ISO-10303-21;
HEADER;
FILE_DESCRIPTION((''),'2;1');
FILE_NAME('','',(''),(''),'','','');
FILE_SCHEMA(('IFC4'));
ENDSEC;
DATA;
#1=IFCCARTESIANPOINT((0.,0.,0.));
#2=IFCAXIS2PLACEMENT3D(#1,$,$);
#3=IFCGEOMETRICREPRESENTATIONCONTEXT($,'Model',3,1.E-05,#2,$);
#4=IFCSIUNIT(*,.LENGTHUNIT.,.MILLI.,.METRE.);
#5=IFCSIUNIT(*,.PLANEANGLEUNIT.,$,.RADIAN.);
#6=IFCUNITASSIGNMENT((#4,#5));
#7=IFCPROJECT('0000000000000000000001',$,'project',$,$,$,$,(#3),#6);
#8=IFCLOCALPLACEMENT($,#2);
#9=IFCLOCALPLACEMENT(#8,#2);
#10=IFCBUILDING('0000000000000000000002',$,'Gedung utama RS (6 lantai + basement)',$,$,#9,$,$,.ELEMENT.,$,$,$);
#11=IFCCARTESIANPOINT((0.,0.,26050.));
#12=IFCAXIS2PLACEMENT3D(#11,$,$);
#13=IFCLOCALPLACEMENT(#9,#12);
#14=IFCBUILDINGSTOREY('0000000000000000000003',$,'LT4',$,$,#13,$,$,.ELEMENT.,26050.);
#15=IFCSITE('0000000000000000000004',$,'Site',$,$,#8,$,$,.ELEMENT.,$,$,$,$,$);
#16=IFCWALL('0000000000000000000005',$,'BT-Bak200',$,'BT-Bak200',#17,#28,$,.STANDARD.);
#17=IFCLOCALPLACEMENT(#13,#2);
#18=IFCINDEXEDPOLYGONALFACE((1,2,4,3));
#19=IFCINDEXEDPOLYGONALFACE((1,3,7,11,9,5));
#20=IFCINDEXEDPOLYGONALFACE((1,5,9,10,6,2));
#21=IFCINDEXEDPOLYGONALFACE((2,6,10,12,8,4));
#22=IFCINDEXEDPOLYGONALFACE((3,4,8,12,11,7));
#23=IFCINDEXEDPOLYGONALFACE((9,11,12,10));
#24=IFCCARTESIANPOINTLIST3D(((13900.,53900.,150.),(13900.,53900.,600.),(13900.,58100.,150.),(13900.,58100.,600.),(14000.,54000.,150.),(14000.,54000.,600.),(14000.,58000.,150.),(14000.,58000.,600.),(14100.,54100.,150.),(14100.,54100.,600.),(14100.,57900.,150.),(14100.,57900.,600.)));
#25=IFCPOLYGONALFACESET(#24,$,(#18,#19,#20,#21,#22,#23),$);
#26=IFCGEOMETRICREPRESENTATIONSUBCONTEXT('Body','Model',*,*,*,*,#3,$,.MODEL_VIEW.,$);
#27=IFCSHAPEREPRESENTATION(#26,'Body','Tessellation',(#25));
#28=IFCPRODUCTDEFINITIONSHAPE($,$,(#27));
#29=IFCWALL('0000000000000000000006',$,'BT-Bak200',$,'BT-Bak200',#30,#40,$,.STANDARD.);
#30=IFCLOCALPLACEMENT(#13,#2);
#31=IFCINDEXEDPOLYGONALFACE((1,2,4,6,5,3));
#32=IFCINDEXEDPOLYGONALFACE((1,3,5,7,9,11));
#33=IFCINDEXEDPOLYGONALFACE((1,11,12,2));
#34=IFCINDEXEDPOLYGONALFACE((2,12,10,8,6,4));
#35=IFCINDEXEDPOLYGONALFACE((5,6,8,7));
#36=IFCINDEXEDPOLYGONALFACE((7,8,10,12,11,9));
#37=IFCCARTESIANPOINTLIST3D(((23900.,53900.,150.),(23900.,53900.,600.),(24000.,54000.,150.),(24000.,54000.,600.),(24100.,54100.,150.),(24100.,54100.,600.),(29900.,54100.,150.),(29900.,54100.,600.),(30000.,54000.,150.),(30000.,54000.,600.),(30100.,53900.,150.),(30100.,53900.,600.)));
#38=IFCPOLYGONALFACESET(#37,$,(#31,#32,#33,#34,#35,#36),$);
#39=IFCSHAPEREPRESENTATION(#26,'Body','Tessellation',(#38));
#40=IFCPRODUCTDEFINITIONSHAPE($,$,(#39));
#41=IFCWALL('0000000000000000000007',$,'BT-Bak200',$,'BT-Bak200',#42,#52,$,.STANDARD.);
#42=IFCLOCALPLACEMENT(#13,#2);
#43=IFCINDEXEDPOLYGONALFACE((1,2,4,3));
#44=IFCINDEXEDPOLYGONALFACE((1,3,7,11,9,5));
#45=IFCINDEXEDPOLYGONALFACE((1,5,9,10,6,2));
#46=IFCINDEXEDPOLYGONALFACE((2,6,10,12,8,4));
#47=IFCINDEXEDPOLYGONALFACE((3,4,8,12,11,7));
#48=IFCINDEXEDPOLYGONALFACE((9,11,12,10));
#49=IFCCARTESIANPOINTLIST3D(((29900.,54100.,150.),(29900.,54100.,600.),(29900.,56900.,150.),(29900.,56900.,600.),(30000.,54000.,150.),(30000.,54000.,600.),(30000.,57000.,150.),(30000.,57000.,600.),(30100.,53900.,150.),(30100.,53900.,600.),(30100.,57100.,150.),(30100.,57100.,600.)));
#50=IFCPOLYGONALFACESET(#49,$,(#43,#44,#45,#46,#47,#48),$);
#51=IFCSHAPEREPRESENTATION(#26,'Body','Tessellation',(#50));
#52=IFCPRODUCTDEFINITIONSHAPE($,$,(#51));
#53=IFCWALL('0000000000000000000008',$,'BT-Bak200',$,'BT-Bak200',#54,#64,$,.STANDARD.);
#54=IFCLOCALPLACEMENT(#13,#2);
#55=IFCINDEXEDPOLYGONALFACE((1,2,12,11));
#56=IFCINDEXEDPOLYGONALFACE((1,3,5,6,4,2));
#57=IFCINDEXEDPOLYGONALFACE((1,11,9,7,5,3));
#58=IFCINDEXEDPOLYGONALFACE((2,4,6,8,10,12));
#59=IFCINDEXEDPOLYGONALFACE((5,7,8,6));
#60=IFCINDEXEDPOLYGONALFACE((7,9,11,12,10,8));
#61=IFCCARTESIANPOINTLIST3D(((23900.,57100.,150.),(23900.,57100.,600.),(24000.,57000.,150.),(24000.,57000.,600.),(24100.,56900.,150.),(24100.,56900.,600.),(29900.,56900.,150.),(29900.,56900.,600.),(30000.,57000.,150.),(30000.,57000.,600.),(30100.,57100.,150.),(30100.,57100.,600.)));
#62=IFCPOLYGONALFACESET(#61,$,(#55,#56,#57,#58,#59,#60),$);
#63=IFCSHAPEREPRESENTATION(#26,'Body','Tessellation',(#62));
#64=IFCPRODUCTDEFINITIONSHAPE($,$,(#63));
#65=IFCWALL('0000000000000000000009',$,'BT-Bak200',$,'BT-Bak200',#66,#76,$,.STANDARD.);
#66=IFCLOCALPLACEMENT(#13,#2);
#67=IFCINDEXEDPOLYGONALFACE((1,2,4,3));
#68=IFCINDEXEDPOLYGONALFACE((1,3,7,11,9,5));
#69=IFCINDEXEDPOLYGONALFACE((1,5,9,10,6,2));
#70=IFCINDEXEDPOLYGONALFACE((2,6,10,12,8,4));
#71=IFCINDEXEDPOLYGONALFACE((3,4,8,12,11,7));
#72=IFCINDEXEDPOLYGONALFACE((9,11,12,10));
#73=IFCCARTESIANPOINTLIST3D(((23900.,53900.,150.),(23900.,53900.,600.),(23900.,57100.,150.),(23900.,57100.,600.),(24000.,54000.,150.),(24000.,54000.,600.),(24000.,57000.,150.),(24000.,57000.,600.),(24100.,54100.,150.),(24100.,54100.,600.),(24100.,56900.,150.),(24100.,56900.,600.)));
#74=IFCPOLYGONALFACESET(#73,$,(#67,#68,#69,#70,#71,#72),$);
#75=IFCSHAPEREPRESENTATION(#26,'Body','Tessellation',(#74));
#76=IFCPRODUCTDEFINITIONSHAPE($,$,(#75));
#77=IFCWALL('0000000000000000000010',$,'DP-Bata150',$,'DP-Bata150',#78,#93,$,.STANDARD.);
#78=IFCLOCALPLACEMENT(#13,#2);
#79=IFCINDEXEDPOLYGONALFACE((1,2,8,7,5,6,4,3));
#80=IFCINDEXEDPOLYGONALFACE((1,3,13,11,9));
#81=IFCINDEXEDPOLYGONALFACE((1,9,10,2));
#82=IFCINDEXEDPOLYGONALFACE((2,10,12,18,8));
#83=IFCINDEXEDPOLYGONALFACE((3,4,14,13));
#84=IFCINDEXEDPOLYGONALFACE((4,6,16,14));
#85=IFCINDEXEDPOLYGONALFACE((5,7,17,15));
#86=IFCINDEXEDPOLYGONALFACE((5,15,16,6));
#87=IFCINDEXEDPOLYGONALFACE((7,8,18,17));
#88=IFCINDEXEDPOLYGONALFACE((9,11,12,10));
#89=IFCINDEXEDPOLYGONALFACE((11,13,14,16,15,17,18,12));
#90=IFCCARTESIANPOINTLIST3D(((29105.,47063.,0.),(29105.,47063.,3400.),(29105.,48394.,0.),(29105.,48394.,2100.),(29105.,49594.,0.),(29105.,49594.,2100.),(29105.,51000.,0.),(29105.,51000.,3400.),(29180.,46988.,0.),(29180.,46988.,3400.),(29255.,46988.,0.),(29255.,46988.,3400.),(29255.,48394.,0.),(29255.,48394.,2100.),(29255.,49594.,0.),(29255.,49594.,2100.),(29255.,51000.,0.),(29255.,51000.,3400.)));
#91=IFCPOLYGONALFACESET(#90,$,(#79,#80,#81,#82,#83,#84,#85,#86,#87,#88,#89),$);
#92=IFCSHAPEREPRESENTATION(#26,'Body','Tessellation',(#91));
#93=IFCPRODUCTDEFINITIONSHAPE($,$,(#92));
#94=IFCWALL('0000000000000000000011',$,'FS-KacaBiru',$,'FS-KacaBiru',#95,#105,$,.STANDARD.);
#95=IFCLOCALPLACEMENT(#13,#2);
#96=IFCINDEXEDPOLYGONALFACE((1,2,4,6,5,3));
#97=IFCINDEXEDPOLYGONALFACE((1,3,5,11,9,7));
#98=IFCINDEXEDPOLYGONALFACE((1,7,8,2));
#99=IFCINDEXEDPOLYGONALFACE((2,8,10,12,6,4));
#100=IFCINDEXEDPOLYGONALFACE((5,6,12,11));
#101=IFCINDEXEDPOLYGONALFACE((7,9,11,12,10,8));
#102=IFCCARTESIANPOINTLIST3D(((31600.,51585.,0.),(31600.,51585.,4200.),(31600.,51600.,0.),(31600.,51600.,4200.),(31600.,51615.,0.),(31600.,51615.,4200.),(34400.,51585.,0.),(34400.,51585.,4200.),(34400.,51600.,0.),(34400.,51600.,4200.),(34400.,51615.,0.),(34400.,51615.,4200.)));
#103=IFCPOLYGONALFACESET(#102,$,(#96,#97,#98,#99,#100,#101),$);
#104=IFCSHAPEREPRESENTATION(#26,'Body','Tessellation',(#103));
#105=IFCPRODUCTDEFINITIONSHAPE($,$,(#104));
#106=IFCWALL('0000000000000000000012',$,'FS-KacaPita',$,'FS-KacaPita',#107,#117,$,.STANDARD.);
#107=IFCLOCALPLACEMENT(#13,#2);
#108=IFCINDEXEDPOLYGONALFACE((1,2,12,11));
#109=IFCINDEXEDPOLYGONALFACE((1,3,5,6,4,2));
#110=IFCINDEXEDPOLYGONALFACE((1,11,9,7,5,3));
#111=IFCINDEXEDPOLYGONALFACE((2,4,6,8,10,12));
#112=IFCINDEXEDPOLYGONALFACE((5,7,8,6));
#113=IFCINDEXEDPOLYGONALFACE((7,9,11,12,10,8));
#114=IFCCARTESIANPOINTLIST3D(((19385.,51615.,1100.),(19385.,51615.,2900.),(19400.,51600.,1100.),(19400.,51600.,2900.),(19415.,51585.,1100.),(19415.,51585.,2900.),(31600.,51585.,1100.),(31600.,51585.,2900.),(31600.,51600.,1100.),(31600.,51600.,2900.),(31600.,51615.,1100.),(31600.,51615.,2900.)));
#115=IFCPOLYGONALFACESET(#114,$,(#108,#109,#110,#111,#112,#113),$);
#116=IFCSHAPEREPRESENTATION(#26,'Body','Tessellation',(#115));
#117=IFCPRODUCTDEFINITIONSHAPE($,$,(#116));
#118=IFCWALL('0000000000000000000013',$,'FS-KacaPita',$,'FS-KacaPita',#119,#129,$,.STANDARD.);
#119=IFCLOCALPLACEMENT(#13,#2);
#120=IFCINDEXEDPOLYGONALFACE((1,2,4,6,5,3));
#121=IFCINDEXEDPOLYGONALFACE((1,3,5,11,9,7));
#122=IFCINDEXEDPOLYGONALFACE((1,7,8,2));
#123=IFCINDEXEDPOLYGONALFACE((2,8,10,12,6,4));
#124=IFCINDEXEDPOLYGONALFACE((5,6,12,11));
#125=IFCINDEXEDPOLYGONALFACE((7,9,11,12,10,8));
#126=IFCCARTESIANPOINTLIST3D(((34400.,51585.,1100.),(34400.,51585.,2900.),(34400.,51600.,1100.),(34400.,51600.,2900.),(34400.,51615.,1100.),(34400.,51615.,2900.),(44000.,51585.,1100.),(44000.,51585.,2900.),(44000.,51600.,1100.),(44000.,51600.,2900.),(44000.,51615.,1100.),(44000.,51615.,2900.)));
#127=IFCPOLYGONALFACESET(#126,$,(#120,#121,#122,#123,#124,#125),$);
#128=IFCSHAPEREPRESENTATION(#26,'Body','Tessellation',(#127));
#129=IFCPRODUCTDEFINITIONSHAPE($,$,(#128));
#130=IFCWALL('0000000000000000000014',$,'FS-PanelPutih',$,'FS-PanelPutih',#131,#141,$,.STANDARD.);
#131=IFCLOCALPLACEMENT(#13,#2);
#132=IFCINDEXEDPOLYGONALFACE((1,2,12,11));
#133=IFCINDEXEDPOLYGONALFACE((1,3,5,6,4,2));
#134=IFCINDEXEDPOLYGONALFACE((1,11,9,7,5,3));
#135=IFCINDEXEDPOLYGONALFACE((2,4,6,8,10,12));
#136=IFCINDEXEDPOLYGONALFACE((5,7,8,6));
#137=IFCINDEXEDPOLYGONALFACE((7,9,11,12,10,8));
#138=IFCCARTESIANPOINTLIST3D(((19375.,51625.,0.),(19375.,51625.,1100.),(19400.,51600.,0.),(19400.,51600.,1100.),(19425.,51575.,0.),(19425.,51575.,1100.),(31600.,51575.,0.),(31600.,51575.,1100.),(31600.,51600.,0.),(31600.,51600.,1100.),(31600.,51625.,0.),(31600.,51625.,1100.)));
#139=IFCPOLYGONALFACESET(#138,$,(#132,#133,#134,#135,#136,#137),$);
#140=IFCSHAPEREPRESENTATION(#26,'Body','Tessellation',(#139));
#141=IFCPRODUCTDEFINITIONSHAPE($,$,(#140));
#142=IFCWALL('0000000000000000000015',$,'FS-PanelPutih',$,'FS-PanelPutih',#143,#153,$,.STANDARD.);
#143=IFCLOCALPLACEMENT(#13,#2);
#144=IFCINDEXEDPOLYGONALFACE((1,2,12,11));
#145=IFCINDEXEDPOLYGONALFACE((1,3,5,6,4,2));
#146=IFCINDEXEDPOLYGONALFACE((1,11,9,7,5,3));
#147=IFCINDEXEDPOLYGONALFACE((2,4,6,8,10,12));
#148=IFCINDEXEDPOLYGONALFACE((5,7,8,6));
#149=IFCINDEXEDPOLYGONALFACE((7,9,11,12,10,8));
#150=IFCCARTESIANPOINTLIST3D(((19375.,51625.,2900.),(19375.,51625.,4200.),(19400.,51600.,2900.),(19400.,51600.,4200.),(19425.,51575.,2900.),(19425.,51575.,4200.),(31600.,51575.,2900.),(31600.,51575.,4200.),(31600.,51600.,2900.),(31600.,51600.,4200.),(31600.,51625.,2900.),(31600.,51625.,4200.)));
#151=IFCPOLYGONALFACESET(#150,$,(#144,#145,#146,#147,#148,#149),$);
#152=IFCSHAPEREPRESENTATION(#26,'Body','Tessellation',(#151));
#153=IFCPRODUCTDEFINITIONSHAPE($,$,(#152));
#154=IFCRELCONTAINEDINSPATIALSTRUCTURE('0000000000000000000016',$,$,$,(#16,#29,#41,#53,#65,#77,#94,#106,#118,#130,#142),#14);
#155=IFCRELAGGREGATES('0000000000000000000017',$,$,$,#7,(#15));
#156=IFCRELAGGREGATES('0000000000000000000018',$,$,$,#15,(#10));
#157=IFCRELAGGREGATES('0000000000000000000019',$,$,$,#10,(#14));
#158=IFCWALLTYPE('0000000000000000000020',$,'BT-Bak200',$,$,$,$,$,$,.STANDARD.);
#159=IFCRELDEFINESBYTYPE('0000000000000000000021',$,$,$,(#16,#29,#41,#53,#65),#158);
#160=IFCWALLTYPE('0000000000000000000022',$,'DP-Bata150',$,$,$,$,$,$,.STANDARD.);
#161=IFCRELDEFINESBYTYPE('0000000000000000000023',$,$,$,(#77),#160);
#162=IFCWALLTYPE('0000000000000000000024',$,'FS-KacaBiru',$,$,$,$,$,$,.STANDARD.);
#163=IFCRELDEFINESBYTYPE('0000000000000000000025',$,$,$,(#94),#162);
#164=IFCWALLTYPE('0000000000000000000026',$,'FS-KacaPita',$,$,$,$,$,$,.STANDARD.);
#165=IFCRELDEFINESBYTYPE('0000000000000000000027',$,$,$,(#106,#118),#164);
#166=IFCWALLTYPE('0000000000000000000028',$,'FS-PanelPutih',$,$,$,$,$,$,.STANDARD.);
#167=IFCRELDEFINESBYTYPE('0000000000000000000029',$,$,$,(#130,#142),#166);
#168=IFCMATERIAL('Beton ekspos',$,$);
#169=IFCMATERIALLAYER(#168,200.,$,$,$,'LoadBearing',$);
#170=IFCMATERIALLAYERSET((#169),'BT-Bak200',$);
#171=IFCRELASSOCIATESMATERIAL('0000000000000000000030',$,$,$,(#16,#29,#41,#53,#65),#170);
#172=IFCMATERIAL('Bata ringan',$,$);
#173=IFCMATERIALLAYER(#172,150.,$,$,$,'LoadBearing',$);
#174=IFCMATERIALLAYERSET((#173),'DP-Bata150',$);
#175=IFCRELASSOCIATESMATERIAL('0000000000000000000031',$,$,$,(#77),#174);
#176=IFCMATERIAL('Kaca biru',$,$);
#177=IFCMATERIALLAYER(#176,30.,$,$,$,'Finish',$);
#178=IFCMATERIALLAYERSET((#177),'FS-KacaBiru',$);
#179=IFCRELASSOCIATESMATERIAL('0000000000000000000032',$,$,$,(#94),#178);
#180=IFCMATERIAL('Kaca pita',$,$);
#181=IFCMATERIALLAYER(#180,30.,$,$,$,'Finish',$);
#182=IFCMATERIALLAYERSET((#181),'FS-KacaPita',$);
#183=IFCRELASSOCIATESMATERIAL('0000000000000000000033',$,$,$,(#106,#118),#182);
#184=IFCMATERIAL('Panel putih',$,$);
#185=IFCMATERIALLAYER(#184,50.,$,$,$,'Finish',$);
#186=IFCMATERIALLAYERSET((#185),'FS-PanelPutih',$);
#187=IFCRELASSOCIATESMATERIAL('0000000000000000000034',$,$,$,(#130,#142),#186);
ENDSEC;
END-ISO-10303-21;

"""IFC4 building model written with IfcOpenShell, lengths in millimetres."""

from ifc_helpers import new_model, si_unit, frame, frame_2d, origin, place, context, subcontext, project, spatial, polyline, rectangle, outline, extrude, material, layer, layer_set, layer_usage, type_object, element, save


model = new_model("IFC4")

# Units and contexts
model_context = context("Model", 3, precision=1e-05, world=origin())
body_context = subcontext(model_context, "Body", "Model", "MODEL_VIEW")
ifc_project = project(units=[si_unit("LENGTHUNIT", "METRE", prefix="MILLI"), si_unit("PLANEANGLEUNIT", "RADIAN")], contexts=[model_context])

# Site, building, storey
site_placement = place(None, origin())
site = spatial("IfcSite", under=ifc_project, at=site_placement, Name="Site", CompositionType="ELEMENT")
building_placement = place(site_placement, origin())
building = spatial("IfcBuilding", under=site, at=building_placement, Name="Gedung utama RS (6 lantai + basement)", CompositionType="ELEMENT")
storey_placement = place(building_placement, frame((0.0, 0.0, 26050.0)))
storey = spatial("IfcBuildingStorey", under=building, at=storey_placement, Name="LT4", CompositionType="ELEMENT", Elevation=26050.0)

# Walls
ifc_material_1 = material(Name="Beton ekspos")
ifc_layer_1 = layer(ifc_material_1, 200.0, Category="LoadBearing")
ifc_layer_set_1 = layer_set([ifc_layer_1], Name="BT-Bak200")
ifc_layer_usage_1 = layer_usage(ifc_layer_set_1, "AXIS2", "NEGATIVE", 100.0)
wall_type_1 = type_object("IfcWallType", Name="BT-Bak200", PredefinedType="STANDARD")
for number, where, z_axis, x_axis, name in (
    (1, (14000.0, 58000.0, 150.0), (0.0, 0.0, 1.0), (0.0, -1.0, 0.0), "BT-Bak200"),
):
    element("IfcWall", number, at=place(storey_placement, frame(where, z_axis=z_axis, x_axis=x_axis)), inside=storey, type_object=wall_type_1, material=ifc_layer_usage_1, Name=name, ObjectType="BT-Bak200", PredefinedType="STANDARD", context=body_context, shape_type="SweptSolid", body=[
        extrude(outline(polyline([(-100.0, -100.0), (0.0, 0.0), (100.0, 100.0), (3900.0, 100.0), (4000.0, 0.0), (4100.0, -100.0), (-100.0, -100.0)])), origin(), (0.0, 0.0, 1.0), 450.0),
    ])
wall_1_placement = place(storey_placement, frame((24000.0, 54000.0, 150.0), z_axis=(0.0, 0.0, 1.0), x_axis=(1.0, 0.0, 0.0)))
element("IfcWall", 2, at=wall_1_placement, inside=storey, type_object=wall_type_1, material=ifc_layer_usage_1, Name="BT-Bak200", ObjectType="BT-Bak200", PredefinedType="STANDARD", context=body_context, shape_type="SweptSolid", body=[
    extrude(outline(polyline([(-100.0, -100.0), (0.0, 0.0), (100.0, 100.0), (5900.0, 100.0), (6000.0, 0.0), (6100.0, -100.0), (-100.0, -100.0)])), origin(), (0.0, 0.0, 1.0), 450.0),
])
wall_2_placement = place(storey_placement, frame((30000.0, 54000.0, 150.0), z_axis=(0.0, 0.0, 1.0), x_axis=(0.0, 1.0, 0.0)))
element("IfcWall", 3, at=wall_2_placement, inside=storey, type_object=wall_type_1, material=ifc_layer_usage_1, Name="BT-Bak200", ObjectType="BT-Bak200", PredefinedType="STANDARD", context=body_context, shape_type="SweptSolid", body=[
    extrude(outline(polyline([(-100.0, -100.0), (0.0, 0.0), (100.0, 100.0), (2900.0, 100.0), (3000.0, 0.0), (3100.0, -100.0), (-100.0, -100.0)])), origin(), (0.0, 0.0, 1.0), 450.0),
])
wall_3_placement = place(storey_placement, frame((30000.0, 57000.0, 150.0), z_axis=(0.0, 0.0, 1.0), x_axis=(-1.0, 0.0, 0.0)))
element("IfcWall", 4, at=wall_3_placement, inside=storey, type_object=wall_type_1, material=ifc_layer_usage_1, Name="BT-Bak200", ObjectType="BT-Bak200", PredefinedType="STANDARD", context=body_context, shape_type="SweptSolid", body=[
    extrude(outline(polyline([(-100.0, -100.0), (0.0, 0.0), (100.0, 100.0), (5900.0, 100.0), (6000.0, 0.0), (6100.0, -100.0), (-100.0, -100.0)])), origin(), (0.0, 0.0, 1.0), 450.0),
])
wall_4_placement = place(storey_placement, frame((24000.0, 57000.0, 150.0), z_axis=(0.0, 0.0, 1.0), x_axis=(0.0, -1.0, 0.0)))
element("IfcWall", 5, at=wall_4_placement, inside=storey, type_object=wall_type_1, material=ifc_layer_usage_1, Name="BT-Bak200", ObjectType="BT-Bak200", PredefinedType="STANDARD", context=body_context, shape_type="SweptSolid", body=[
    extrude(outline(polyline([(-100.0, -100.0), (0.0, 0.0), (100.0, 100.0), (2900.0, 100.0), (3000.0, 0.0), (3100.0, -100.0), (-100.0, -100.0)])), origin(), (0.0, 0.0, 1.0), 450.0),
])

# Wall, opening
ifc_material_2 = material(Name="Bata ringan")
ifc_layer_2 = layer(ifc_material_2, 150.0, Category="LoadBearing")
ifc_layer_set_2 = layer_set([ifc_layer_2], Name="DP-Bata150")
ifc_layer_usage_2 = layer_usage(ifc_layer_set_2, "AXIS2", "NEGATIVE", 75.0)
wall_type_2 = type_object("IfcWallType", Name="DP-Bata150", PredefinedType="STANDARD")
wall_5_placement = place(storey_placement, frame((29180.0, 46988.0, 0.0), z_axis=(0.0, 0.0, 1.0), x_axis=(0.0, 1.0, 0.0)))
wall_5 = element("IfcWall", 6, at=wall_5_placement, inside=storey, type_object=wall_type_2, material=ifc_layer_usage_2, Name="DP-Bata150", ObjectType="DP-Bata150", PredefinedType="STANDARD", context=body_context, shape_type="SweptSolid", body=[
    extrude(outline(polyline([(0.0, -75.0), (0.0, 0.0), (75.0, 75.0), (4012.0, 75.0), (4012.0, -75.0), (0.0, -75.0)])), origin(), (0.0, 0.0, 1.0), 3400.0),
])
opening_placement = place(wall_5_placement, frame((1406.0, 0.0, 0.0), z_axis=(0.0, 0.0, 1.0), x_axis=(1.0, 0.0, 0.0)))
element("IfcOpeningElement", 7, at=opening_placement, cuts=wall_5, PredefinedType="OPENING", context=body_context, shape_type="SweptSolid", body=[
    extrude(rectangle(XDim=1200.0, YDim=170.0, at=frame_2d((600.0, 0.0))), origin(), (0.0, 0.0, 1.0), 2100.0),
])

# Walls
ifc_material_3 = material(Name="Kaca biru")
ifc_layer_3 = layer(ifc_material_3, 30.0, Category="Finish")
ifc_layer_set_3 = layer_set([ifc_layer_3], Name="FS-KacaBiru")
ifc_layer_usage_3 = layer_usage(ifc_layer_set_3, "AXIS2", "NEGATIVE", 15.0)
wall_type_3 = type_object("IfcWallType", Name="FS-KacaBiru", PredefinedType="STANDARD")
wall_6_placement = place(storey_placement, frame((31600.0, 51600.0, 0.0), z_axis=(0.0, 0.0, 1.0), x_axis=(1.0, 0.0, 0.0)))
element("IfcWall", 8, at=wall_6_placement, inside=storey, type_object=wall_type_3, material=ifc_layer_usage_3, Name="FS-KacaBiru", ObjectType="FS-KacaBiru", PredefinedType="STANDARD", context=body_context, shape_type="SweptSolid", body=[
    extrude(outline(polyline([(0.0, -15.0), (0.0, 0.0), (0.0, 15.0), (2800.0, 15.0), (2800.0, 0.0), (2800.0, -15.0), (0.0, -15.0)])), origin(), (0.0, 0.0, 1.0), 4200.0),
])
ifc_material_4 = material(Name="Kaca pita")
ifc_layer_4 = layer(ifc_material_4, 30.0, Category="Finish")
ifc_layer_set_4 = layer_set([ifc_layer_4], Name="FS-KacaPita")
ifc_layer_usage_4 = layer_usage(ifc_layer_set_4, "AXIS2", "NEGATIVE", 15.0)
wall_type_4 = type_object("IfcWallType", Name="FS-KacaPita", PredefinedType="STANDARD")
wall_7_placement = place(storey_placement, frame((19400.0, 51600.0, 1100.0), z_axis=(0.0, 0.0, 1.0), x_axis=(1.0, 0.0, 0.0)))
element("IfcWall", 9, at=wall_7_placement, inside=storey, type_object=wall_type_4, material=ifc_layer_usage_4, Name="FS-KacaPita", ObjectType="FS-KacaPita", PredefinedType="STANDARD", context=body_context, shape_type="SweptSolid", body=[
    extrude(outline(polyline([(15.0, -15.0), (0.0, 0.0), (-15.0, 15.0), (12200.0, 15.0), (12200.0, 0.0), (12200.0, -15.0), (15.0, -15.0)])), origin(), (0.0, 0.0, 1.0), 1800.0),
])
wall_8_placement = place(storey_placement, frame((34400.0, 51600.0, 1100.0), z_axis=(0.0, 0.0, 1.0), x_axis=(1.0, 0.0, 0.0)))
element("IfcWall", 10, at=wall_8_placement, inside=storey, type_object=wall_type_4, material=ifc_layer_usage_4, Name="FS-KacaPita", ObjectType="FS-KacaPita", PredefinedType="STANDARD", context=body_context, shape_type="SweptSolid", body=[
    extrude(outline(polyline([(0.0, -15.0), (0.0, 0.0), (0.0, 15.0), (9600.0, 15.0), (9600.0, 0.0), (9600.0, -15.0), (0.0, -15.0)])), origin(), (0.0, 0.0, 1.0), 1800.0),
])
ifc_material_5 = material(Name="Panel putih")
ifc_layer_5 = layer(ifc_material_5, 50.0, Category="Finish")
ifc_layer_set_5 = layer_set([ifc_layer_5], Name="FS-PanelPutih")
ifc_layer_usage_5 = layer_usage(ifc_layer_set_5, "AXIS2", "NEGATIVE", 25.0)
wall_type_5 = type_object("IfcWallType", Name="FS-PanelPutih", PredefinedType="STANDARD")
wall_9_placement = place(storey_placement, frame((19400.0, 51600.0, 0.0), z_axis=(0.0, 0.0, 1.0), x_axis=(1.0, 0.0, 0.0)))
element("IfcWall", 11, at=wall_9_placement, inside=storey, type_object=wall_type_5, material=ifc_layer_usage_5, Name="FS-PanelPutih", ObjectType="FS-PanelPutih", PredefinedType="STANDARD", context=body_context, shape_type="SweptSolid", body=[
    extrude(outline(polyline([(25.0, -25.0), (0.0, 0.0), (-25.0, 25.0), (12200.0, 25.0), (12200.0, 0.0), (12200.0, -25.0), (25.0, -25.0)])), origin(), (0.0, 0.0, 1.0), 1100.0),
])
wall_10_placement = place(storey_placement, frame((19400.0, 51600.0, 2900.0), z_axis=(0.0, 0.0, 1.0), x_axis=(1.0, 0.0, 0.0)))
element("IfcWall", 12, at=wall_10_placement, inside=storey, type_object=wall_type_5, material=ifc_layer_usage_5, Name="FS-PanelPutih", ObjectType="FS-PanelPutih", PredefinedType="STANDARD", context=body_context, shape_type="SweptSolid", body=[
    extrude(outline(polyline([(25.0, -25.0), (0.0, 0.0), (-25.0, 25.0), (12200.0, 25.0), (12200.0, 0.0), (12200.0, -25.0), (25.0, -25.0)])), origin(), (0.0, 0.0, 1.0), 1300.0),
])

save(model, "model.ifc")
